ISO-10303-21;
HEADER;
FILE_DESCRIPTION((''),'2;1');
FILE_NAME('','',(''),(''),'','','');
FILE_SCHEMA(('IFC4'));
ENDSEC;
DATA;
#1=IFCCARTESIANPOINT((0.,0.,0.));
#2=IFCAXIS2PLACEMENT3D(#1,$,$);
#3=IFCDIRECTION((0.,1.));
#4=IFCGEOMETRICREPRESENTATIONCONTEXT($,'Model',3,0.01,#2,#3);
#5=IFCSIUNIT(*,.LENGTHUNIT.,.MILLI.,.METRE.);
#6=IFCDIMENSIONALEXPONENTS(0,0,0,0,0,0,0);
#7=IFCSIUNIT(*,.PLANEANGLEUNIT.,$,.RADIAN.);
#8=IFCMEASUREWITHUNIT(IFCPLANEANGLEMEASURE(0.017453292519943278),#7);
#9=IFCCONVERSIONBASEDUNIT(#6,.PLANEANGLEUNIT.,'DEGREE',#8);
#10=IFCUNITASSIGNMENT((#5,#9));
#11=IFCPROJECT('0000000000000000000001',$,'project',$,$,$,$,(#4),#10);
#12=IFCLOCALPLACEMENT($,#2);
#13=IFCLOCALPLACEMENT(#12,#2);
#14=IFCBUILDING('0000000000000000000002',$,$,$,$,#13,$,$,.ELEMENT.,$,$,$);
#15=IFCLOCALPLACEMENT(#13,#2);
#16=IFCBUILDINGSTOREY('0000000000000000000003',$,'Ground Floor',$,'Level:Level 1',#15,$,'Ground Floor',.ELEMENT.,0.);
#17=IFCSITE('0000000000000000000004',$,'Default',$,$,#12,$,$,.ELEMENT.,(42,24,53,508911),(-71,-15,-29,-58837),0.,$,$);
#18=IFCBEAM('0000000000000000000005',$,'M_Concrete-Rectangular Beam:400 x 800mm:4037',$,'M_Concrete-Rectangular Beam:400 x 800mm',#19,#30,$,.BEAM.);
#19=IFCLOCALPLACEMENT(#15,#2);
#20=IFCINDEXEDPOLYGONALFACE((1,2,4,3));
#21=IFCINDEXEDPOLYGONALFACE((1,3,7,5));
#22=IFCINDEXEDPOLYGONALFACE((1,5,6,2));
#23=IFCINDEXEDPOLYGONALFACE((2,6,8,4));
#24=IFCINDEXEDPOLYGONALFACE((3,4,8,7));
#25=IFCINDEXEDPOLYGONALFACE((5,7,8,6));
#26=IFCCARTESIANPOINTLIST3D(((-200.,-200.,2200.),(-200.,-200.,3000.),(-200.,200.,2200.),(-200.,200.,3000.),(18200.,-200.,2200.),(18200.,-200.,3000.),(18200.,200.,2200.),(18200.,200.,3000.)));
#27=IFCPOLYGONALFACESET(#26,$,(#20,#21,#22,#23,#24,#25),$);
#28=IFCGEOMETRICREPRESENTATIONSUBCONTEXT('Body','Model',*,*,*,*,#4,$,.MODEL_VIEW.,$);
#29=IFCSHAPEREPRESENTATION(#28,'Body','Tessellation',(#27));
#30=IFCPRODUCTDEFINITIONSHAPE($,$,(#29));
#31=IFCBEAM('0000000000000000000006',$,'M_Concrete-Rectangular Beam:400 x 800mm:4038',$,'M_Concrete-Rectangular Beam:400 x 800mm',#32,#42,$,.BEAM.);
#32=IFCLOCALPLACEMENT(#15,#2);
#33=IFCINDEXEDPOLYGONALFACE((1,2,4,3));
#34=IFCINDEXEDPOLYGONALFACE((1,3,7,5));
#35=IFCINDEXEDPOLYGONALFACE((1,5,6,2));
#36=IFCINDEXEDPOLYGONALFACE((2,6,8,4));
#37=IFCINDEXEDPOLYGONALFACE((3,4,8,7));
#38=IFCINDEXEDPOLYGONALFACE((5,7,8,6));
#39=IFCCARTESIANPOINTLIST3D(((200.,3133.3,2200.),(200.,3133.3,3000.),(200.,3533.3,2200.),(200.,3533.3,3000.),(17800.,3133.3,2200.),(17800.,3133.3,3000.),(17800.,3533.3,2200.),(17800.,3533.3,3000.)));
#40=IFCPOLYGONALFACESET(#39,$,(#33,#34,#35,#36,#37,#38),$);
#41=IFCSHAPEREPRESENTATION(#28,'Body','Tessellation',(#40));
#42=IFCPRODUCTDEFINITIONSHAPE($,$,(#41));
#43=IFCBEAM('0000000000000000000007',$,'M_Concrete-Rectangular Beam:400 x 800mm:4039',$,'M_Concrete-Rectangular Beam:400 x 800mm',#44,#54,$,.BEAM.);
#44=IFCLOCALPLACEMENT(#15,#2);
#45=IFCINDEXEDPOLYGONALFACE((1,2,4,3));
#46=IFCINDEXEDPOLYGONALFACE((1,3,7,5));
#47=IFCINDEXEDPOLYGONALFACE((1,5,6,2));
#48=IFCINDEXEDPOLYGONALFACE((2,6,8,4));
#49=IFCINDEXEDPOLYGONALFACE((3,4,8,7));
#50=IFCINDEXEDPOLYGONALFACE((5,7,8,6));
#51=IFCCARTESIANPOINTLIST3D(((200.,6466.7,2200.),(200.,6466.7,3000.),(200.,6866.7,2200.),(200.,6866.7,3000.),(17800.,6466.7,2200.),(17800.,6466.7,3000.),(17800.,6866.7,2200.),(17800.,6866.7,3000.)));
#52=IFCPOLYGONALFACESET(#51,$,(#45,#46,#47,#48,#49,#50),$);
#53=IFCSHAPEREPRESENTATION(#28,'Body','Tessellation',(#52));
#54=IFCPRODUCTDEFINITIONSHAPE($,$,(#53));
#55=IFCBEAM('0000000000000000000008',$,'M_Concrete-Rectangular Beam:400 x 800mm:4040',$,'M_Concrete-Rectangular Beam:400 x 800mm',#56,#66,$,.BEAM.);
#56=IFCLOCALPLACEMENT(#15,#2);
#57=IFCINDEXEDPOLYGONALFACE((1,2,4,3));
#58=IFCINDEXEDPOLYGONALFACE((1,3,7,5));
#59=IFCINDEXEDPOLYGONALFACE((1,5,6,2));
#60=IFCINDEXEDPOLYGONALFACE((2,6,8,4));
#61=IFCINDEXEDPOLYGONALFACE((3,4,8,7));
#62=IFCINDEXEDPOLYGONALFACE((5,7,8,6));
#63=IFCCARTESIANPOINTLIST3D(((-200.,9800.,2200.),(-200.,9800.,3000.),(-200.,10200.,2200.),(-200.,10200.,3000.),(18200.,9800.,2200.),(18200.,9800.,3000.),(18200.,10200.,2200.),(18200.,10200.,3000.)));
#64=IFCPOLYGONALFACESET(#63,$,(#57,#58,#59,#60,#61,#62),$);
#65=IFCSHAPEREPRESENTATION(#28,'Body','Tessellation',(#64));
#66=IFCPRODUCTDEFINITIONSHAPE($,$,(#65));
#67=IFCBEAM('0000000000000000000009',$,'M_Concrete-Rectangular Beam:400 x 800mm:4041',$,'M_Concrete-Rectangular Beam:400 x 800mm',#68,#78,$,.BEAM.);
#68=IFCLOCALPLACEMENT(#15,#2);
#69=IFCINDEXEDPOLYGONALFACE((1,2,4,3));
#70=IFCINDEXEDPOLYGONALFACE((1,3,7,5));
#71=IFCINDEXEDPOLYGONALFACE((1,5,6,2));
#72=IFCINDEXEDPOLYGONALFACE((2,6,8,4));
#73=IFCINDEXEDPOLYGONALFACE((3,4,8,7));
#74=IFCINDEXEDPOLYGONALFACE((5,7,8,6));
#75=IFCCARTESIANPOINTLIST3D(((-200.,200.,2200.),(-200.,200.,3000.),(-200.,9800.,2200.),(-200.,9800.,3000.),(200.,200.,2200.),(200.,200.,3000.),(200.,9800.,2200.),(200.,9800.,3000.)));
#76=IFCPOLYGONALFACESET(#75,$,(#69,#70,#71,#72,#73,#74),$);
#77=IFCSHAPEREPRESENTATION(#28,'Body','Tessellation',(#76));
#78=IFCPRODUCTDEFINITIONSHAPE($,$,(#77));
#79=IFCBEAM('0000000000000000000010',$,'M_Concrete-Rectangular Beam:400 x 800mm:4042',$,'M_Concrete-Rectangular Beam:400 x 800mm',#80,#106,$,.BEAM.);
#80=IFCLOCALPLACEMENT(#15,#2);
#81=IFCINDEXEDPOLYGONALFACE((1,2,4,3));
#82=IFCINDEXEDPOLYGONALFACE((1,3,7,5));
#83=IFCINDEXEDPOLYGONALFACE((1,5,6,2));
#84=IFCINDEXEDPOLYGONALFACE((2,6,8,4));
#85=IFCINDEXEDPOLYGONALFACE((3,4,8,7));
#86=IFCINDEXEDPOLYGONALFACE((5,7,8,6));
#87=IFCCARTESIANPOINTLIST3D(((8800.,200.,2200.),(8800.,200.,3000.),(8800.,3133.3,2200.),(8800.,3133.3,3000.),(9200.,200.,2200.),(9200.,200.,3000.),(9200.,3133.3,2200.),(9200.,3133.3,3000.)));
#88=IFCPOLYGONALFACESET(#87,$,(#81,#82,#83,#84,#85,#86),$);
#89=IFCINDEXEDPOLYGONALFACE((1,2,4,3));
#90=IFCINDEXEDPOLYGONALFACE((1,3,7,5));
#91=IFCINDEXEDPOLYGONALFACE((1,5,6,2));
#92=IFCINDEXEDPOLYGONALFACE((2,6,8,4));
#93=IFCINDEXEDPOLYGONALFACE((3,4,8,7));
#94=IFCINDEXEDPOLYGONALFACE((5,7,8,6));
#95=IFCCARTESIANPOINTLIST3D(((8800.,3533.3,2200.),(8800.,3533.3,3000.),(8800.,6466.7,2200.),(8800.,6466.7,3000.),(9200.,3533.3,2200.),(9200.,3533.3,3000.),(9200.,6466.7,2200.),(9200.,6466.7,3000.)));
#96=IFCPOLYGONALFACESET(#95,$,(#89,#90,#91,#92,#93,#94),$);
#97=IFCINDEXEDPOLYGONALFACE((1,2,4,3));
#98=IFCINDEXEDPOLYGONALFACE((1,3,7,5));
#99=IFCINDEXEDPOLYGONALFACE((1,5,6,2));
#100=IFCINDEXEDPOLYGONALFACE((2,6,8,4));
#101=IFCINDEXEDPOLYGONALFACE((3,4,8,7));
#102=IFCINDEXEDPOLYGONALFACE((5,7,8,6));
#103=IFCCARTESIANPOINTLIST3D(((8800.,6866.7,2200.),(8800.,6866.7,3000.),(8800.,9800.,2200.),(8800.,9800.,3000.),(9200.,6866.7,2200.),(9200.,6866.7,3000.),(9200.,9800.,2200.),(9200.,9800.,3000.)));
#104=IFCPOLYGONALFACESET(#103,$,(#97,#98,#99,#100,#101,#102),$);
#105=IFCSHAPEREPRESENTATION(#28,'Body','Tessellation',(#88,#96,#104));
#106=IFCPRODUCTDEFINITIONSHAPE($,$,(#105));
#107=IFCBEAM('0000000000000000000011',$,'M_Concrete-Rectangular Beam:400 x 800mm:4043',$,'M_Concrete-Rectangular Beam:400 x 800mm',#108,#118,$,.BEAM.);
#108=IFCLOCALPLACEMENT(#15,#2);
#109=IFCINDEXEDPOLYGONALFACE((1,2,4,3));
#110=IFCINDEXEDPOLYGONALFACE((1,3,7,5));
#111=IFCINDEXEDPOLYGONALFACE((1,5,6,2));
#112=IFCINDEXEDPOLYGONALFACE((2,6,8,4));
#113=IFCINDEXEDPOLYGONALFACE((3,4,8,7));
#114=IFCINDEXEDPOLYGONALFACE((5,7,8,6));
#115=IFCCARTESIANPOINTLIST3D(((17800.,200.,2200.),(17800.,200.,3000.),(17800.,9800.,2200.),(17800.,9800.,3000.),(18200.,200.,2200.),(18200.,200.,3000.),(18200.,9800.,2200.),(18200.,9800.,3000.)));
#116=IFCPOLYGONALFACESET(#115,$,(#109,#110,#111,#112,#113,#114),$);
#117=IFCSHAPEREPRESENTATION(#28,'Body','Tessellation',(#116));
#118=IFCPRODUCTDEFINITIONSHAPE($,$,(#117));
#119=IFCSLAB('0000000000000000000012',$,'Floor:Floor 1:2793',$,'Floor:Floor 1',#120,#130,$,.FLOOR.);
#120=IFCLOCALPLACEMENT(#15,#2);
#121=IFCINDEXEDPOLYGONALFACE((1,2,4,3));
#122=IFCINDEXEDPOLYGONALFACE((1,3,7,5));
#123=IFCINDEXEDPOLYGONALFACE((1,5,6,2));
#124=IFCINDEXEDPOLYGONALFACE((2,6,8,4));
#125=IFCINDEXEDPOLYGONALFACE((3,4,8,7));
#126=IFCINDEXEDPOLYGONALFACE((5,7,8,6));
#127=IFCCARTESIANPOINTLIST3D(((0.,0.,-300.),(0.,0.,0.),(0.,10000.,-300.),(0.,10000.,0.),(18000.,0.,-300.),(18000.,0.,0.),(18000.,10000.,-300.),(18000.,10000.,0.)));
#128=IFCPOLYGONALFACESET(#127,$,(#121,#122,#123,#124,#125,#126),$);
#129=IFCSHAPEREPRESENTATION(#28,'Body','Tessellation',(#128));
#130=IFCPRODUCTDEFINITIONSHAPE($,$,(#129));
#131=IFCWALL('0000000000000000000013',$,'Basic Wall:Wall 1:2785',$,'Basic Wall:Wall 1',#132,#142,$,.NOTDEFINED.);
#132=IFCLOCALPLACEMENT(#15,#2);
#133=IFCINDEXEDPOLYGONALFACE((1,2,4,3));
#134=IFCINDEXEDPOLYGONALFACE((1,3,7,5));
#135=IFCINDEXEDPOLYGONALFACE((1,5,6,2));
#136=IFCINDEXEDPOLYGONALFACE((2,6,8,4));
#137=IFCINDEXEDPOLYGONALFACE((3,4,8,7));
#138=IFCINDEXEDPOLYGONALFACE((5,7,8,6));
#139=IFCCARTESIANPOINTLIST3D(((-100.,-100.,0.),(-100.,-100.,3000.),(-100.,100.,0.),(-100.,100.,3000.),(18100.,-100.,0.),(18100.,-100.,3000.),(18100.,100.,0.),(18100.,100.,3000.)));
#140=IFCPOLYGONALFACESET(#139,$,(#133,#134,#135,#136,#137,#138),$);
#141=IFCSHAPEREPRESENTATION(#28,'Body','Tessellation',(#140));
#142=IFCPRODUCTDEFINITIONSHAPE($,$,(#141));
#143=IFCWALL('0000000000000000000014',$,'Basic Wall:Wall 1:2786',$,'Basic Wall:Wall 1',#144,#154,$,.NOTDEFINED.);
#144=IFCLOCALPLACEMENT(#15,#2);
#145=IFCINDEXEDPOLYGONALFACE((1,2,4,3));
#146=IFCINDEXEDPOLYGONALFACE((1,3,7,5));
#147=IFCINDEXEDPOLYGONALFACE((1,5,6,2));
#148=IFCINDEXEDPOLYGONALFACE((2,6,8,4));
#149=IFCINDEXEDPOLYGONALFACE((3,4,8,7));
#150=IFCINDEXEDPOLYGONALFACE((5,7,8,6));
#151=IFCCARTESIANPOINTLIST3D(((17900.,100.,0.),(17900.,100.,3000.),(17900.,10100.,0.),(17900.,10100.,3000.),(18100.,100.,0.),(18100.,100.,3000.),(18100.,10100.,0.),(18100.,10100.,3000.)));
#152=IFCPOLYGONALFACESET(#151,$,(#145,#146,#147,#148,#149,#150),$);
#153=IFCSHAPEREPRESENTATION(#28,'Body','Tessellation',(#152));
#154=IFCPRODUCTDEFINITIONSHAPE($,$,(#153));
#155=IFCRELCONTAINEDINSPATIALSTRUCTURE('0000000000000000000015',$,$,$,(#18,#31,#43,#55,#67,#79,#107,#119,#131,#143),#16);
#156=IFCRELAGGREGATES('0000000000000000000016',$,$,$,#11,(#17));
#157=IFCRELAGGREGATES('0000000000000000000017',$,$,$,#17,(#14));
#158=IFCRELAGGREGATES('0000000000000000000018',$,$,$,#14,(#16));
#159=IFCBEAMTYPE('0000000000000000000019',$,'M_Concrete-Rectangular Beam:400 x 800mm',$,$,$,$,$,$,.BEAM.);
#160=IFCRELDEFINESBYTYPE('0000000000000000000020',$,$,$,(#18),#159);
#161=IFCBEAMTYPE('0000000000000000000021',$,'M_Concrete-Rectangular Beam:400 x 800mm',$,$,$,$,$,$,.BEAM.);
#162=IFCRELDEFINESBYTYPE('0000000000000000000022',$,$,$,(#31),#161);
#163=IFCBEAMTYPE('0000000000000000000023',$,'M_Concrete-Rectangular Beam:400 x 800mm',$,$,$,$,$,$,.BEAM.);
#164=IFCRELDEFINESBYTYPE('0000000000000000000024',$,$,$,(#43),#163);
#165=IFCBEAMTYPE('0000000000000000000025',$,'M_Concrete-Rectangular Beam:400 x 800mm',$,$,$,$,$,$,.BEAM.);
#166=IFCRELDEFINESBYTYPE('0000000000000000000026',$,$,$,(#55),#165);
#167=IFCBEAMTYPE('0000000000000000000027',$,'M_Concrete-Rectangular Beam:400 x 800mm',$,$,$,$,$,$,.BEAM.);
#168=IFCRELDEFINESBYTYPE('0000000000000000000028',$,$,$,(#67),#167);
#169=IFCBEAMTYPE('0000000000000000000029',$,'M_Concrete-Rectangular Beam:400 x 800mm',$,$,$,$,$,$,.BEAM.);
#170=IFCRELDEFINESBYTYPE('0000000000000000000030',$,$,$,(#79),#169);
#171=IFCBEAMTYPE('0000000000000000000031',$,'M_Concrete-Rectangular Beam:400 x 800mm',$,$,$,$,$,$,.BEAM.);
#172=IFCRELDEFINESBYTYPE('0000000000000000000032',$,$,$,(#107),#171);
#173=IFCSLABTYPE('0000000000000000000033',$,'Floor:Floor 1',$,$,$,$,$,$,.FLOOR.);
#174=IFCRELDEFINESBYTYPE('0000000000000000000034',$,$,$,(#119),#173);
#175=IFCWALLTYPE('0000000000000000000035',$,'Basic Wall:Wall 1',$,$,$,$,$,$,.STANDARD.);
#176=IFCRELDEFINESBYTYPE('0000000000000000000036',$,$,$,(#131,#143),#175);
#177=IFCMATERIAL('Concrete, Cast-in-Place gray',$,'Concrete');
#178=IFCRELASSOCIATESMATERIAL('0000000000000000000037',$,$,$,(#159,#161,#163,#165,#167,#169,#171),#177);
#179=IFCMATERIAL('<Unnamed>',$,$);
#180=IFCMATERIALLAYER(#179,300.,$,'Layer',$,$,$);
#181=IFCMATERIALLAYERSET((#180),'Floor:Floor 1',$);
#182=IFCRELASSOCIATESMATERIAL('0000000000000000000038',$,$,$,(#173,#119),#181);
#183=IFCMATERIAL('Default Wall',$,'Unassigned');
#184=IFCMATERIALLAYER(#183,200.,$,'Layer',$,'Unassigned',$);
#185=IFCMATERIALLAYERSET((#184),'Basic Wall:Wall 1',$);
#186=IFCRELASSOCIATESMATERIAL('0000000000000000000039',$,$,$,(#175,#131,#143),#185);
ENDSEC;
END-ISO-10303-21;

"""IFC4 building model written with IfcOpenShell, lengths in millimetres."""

from ifc_helpers import new_model, entity, si_unit, converted_unit, direction, frame, frame_2d, origin, origin_2d_with_axis, place, context, subcontext, project, spatial, rectangle, extrude, source, transform, mapped, material, layer, layer_set, layer_usage, material_profile, profile_set, type_object, type_shapes, element, save


model = new_model("IFC4")

# Units and contexts
model_context = context("Model", 3, precision=0.01, world=origin(), true_north=direction((0.0, 1.0)))
body_context = subcontext(model_context, "Body", "Model", "MODEL_VIEW")
ifc_project = project(units=[si_unit("LENGTHUNIT", "METRE", prefix="MILLI"), converted_unit("PLANEANGLEUNIT", "DEGREE", entity("IfcPlaneAngleMeasure", 0.017453292519943278), si_unit("PLANEANGLEUNIT", "RADIAN"), dimensions=[0, 0, 0, 0, 0, 0, 0])], contexts=[model_context])

# Site, building, storey
site_placement = place(None, origin())
site = spatial("IfcSite", under=ifc_project, at=site_placement, Name="Default", CompositionType="ELEMENT", RefLatitude=(42, 24, 53, 508911), RefLongitude=(-71, -15, -29, -58837), RefElevation=0.0)
building_placement = place(site_placement, origin())
building = spatial("IfcBuilding", under=site, at=building_placement, CompositionType="ELEMENT")
storey_placement = place(building_placement, origin())
storey = spatial("IfcBuildingStorey", under=building, at=storey_placement, Name="Ground Floor", ObjectType="Level:Level 1", LongName="Ground Floor", CompositionType="ELEMENT", Elevation=0.0)

# Shared definitions
ifc_material_1 = material(Name="Default Wall", Category="Unassigned")

# Beams
ifc_material_2 = material(Name="Concrete, Cast-in-Place gray", Category="Concrete")
ifc_material_profile_1 = material_profile(ifc_material_2, rectangle(XDim=800.0, YDim=400.0, at=origin_2d_with_axis()), Name="400 x 800mm")
ifc_profile_set_1 = profile_set([ifc_material_profile_1], Name="400 x 800mm")
beam_type_1 = type_object("IfcBeamType", Name="M_Concrete-Rectangular Beam:400 x 800mm", PredefinedType="BEAM", material=ifc_profile_set_1)
shared_shape_1 = source(origin(), body_context, "Body", "SweptSolid", [
    extrude(rectangle(XDim=800.0, YDim=400.0, at=origin_2d_with_axis()), frame((-200.0, 0.0, 2600.0), z_axis=(1.0, 0.0, 0.0), x_axis=(0.0, 0.0, -1.0)), (0.0, 0.0, 1.0), 18400.0),
])
type_shapes(beam_type_1, [shared_shape_1])
beam_1_placement = place(storey_placement, origin())
element("IfcBeam", 1, at=beam_1_placement, inside=storey, type_object=beam_type_1, Name="M_Concrete-Rectangular Beam:400 x 800mm:4037", ObjectType="M_Concrete-Rectangular Beam:400 x 800mm", PredefinedType="BEAM", context=body_context, shape_type="MappedRepresentation", body=[
    mapped(shared_shape_1, transform((0.0, 0.0, 0.0), scale=1.0)),
])
beam_type_2 = type_object("IfcBeamType", Name="M_Concrete-Rectangular Beam:400 x 800mm", PredefinedType="BEAM", material=ifc_profile_set_1)
shared_shape_2 = source(origin(), body_context, "Body", "SweptSolid", [
    extrude(rectangle(XDim=800.0, YDim=400.0, at=frame_2d((0.0, 0.0), x_axis=(1.0, 0.0))), frame((200.0, 3333.3, 2600.0), z_axis=(1.0, 0.0, 0.0), x_axis=(0.0, 0.0, -1.0)), (0.0, 0.0, 1.0), 17600.0),
])
type_shapes(beam_type_2, [shared_shape_2])
beam_2_placement = place(storey_placement, origin())
element("IfcBeam", 2, at=beam_2_placement, inside=storey, type_object=beam_type_2, Name="M_Concrete-Rectangular Beam:400 x 800mm:4038", ObjectType="M_Concrete-Rectangular Beam:400 x 800mm", PredefinedType="BEAM", context=body_context, shape_type="MappedRepresentation", body=[
    mapped(shared_shape_2, transform((0.0, 0.0, 0.0), scale=1.0)),
])
beam_type_3 = type_object("IfcBeamType", Name="M_Concrete-Rectangular Beam:400 x 800mm", PredefinedType="BEAM", material=ifc_profile_set_1)
shared_shape_3 = source(origin(), body_context, "Body", "SweptSolid", [
    extrude(rectangle(XDim=800.0, YDim=400.0, at=frame_2d((0.0, 0.0), x_axis=(1.0, 0.0))), frame((200.0, 6666.7, 2600.0), z_axis=(1.0, 0.0, 0.0), x_axis=(0.0, 0.0, -1.0)), (0.0, 0.0, 1.0), 17600.0),
])
type_shapes(beam_type_3, [shared_shape_3])
beam_3_placement = place(storey_placement, origin())
element("IfcBeam", 3, at=beam_3_placement, inside=storey, type_object=beam_type_3, Name="M_Concrete-Rectangular Beam:400 x 800mm:4039", ObjectType="M_Concrete-Rectangular Beam:400 x 800mm", PredefinedType="BEAM", context=body_context, shape_type="MappedRepresentation", body=[
    mapped(shared_shape_3, transform((0.0, 0.0, 0.0), scale=1.0)),
])
beam_type_4 = type_object("IfcBeamType", Name="M_Concrete-Rectangular Beam:400 x 800mm", PredefinedType="BEAM", material=ifc_profile_set_1)
shared_shape_4 = source(origin(), body_context, "Body", "SweptSolid", [
    extrude(rectangle(XDim=800.0, YDim=400.0, at=frame_2d((0.0, 0.0), x_axis=(1.0, 0.0))), frame((-200.0, 10000.0, 2600.0), z_axis=(1.0, 0.0, 0.0), x_axis=(0.0, 0.0, -1.0)), (0.0, 0.0, 1.0), 18400.0),
])
type_shapes(beam_type_4, [shared_shape_4])
beam_4_placement = place(storey_placement, origin())
element("IfcBeam", 4, at=beam_4_placement, inside=storey, type_object=beam_type_4, Name="M_Concrete-Rectangular Beam:400 x 800mm:4040", ObjectType="M_Concrete-Rectangular Beam:400 x 800mm", PredefinedType="BEAM", context=body_context, shape_type="MappedRepresentation", body=[
    mapped(shared_shape_4, transform((0.0, 0.0, 0.0), scale=1.0)),
])
beam_type_5 = type_object("IfcBeamType", Name="M_Concrete-Rectangular Beam:400 x 800mm", PredefinedType="BEAM", material=ifc_profile_set_1)
shared_shape_5 = source(origin(), body_context, "Body", "SweptSolid", [
    extrude(rectangle(XDim=800.0, YDim=400.0, at=frame_2d((0.0, 0.0), x_axis=(0.0, 1.0))), frame((0.0, 200.0, 2600.0), z_axis=(0.0, 1.0, 0.0), x_axis=(-1.0, 0.0, 0.0)), (0.0, 0.0, 1.0), 9600.0),
])
type_shapes(beam_type_5, [shared_shape_5])
beam_5_placement = place(storey_placement, origin())
element("IfcBeam", 5, at=beam_5_placement, inside=storey, type_object=beam_type_5, Name="M_Concrete-Rectangular Beam:400 x 800mm:4041", ObjectType="M_Concrete-Rectangular Beam:400 x 800mm", PredefinedType="BEAM", context=body_context, shape_type="MappedRepresentation", body=[
    mapped(shared_shape_5, transform((0.0, 0.0, 0.0), scale=1.0)),
])
beam_type_6 = type_object("IfcBeamType", Name="M_Concrete-Rectangular Beam:400 x 800mm", PredefinedType="BEAM", material=ifc_profile_set_1)
shared_shape_6 = source(origin(), body_context, "Body", "SweptSolid", [
    extrude(rectangle(XDim=800.0, YDim=400.0, at=frame_2d((0.0, 0.0), x_axis=(0.0, 1.0))), frame((9000.0, 200.0, 2600.0), z_axis=(0.0, 1.0, 0.0), x_axis=(-1.0, 0.0, 0.0)), (0.0, 0.0, 1.0), 2933.3),
    extrude(rectangle(XDim=800.0, YDim=400.0, at=frame_2d((0.0, 0.0), x_axis=(0.0, 1.0))), frame((9000.0, 3533.3, 2600.0), z_axis=(0.0, 1.0, 0.0), x_axis=(-1.0, 0.0, 0.0)), (0.0, 0.0, 1.0), 2933.3),
    extrude(rectangle(XDim=800.0, YDim=400.0, at=frame_2d((0.0, 0.0), x_axis=(0.0, 1.0))), frame((9000.0, 6866.7, 2600.0), z_axis=(0.0, 1.0, 0.0), x_axis=(-1.0, 0.0, 0.0)), (0.0, 0.0, 1.0), 2933.3),
])
type_shapes(beam_type_6, [shared_shape_6])
beam_6_placement = place(storey_placement, origin())
element("IfcBeam", 6, at=beam_6_placement, inside=storey, type_object=beam_type_6, Name="M_Concrete-Rectangular Beam:400 x 800mm:4042", ObjectType="M_Concrete-Rectangular Beam:400 x 800mm", PredefinedType="BEAM", context=body_context, shape_type="MappedRepresentation", body=[
    mapped(shared_shape_6, transform((0.0, 0.0, 0.0), scale=1.0)),
])
beam_type_7 = type_object("IfcBeamType", Name="M_Concrete-Rectangular Beam:400 x 800mm", PredefinedType="BEAM", material=ifc_profile_set_1)
shared_shape_7 = source(origin(), body_context, "Body", "SweptSolid", [
    extrude(rectangle(XDim=800.0, YDim=400.0, at=frame_2d((0.0, 0.0), x_axis=(0.0, 1.0))), frame((18000.0, 200.0, 2600.0), z_axis=(0.0, 1.0, 0.0), x_axis=(-1.0, 0.0, 0.0)), (0.0, 0.0, 1.0), 9600.0),
])
type_shapes(beam_type_7, [shared_shape_7])
beam_7_placement = place(storey_placement, origin())
element("IfcBeam", 7, at=beam_7_placement, inside=storey, type_object=beam_type_7, Name="M_Concrete-Rectangular Beam:400 x 800mm:4043", ObjectType="M_Concrete-Rectangular Beam:400 x 800mm", PredefinedType="BEAM", context=body_context, shape_type="MappedRepresentation", body=[
    mapped(shared_shape_7, transform((0.0, 0.0, 0.0), scale=1.0)),
])

# Slab
ifc_material_3 = material(Name="<Unnamed>")
ifc_layer_1 = layer(ifc_material_3, 300.0, Name="Layer")
ifc_layer_set_1 = layer_set([ifc_layer_1], Name="Floor:Floor 1")
ifc_layer_usage_1 = layer_usage(ifc_layer_set_1, "AXIS3", "POSITIVE", 0.0)
slab_type = type_object("IfcSlabType", Name="Floor:Floor 1", PredefinedType="FLOOR", material=ifc_layer_set_1)
slab_placement = place(storey_placement, origin())
element("IfcSlab", 8, at=slab_placement, inside=storey, type_object=slab_type, material=ifc_layer_usage_1, Name="Floor:Floor 1:2793", ObjectType="Floor:Floor 1", PredefinedType="FLOOR", context=body_context, shape_type="SweptSolid", body=[
    extrude(rectangle(XDim=10000.0, YDim=18000.0, at=origin_2d_with_axis()), frame((9000.0, 5000.0, 0.0), z_axis=(0.0, 0.0, -1.0), x_axis=(0.0, 1.0, 0.0)), (0.0, 0.0, 1.0), 300.0),
])

# Walls
ifc_layer_2 = layer(ifc_material_1, 200.0, Name="Layer", Category="Unassigned")
ifc_layer_set_2 = layer_set([ifc_layer_2], Name="Basic Wall:Wall 1")
ifc_layer_usage_2 = layer_usage(ifc_layer_set_2, "AXIS2", "NEGATIVE", 100.0)
wall_type = type_object("IfcWallType", Name="Basic Wall:Wall 1", PredefinedType="STANDARD", material=ifc_layer_set_2)
wall_1_placement = place(storey_placement, frame((-100.0, 0.0, 0.0)))
element("IfcWall", 9, at=wall_1_placement, inside=storey, type_object=wall_type, material=ifc_layer_usage_2, Name="Basic Wall:Wall 1:2785", ObjectType="Basic Wall:Wall 1", PredefinedType="NOTDEFINED", context=body_context, shape_type="SweptSolid", body=[
    extrude(rectangle(XDim=18200.0, YDim=200.0, at=frame_2d((9100.0, 0.0), x_axis=(-1.0, 0.0))), origin(), (0.0, 0.0, 1.0), 3000.0),
])
ifc_layer_usage_3 = layer_usage(ifc_layer_set_2, "AXIS2", "NEGATIVE", 100.0)
wall_2_placement = place(storey_placement, frame((18000.0, 100.0, 0.0), z_axis=(0.0, 0.0, 1.0), x_axis=(0.0, 1.0, 0.0)))
element("IfcWall", 10, at=wall_2_placement, inside=storey, type_object=wall_type, material=ifc_layer_usage_3, Name="Basic Wall:Wall 1:2786", ObjectType="Basic Wall:Wall 1", PredefinedType="NOTDEFINED", context=body_context, shape_type="SweptSolid", body=[
    extrude(rectangle(XDim=10000.0, YDim=200.0, at=frame_2d((5000.0, 0.0), x_axis=(-1.0, 0.0))), origin(), (0.0, 0.0, 1.0), 3000.0),
])

save(model, "model.ifc")
